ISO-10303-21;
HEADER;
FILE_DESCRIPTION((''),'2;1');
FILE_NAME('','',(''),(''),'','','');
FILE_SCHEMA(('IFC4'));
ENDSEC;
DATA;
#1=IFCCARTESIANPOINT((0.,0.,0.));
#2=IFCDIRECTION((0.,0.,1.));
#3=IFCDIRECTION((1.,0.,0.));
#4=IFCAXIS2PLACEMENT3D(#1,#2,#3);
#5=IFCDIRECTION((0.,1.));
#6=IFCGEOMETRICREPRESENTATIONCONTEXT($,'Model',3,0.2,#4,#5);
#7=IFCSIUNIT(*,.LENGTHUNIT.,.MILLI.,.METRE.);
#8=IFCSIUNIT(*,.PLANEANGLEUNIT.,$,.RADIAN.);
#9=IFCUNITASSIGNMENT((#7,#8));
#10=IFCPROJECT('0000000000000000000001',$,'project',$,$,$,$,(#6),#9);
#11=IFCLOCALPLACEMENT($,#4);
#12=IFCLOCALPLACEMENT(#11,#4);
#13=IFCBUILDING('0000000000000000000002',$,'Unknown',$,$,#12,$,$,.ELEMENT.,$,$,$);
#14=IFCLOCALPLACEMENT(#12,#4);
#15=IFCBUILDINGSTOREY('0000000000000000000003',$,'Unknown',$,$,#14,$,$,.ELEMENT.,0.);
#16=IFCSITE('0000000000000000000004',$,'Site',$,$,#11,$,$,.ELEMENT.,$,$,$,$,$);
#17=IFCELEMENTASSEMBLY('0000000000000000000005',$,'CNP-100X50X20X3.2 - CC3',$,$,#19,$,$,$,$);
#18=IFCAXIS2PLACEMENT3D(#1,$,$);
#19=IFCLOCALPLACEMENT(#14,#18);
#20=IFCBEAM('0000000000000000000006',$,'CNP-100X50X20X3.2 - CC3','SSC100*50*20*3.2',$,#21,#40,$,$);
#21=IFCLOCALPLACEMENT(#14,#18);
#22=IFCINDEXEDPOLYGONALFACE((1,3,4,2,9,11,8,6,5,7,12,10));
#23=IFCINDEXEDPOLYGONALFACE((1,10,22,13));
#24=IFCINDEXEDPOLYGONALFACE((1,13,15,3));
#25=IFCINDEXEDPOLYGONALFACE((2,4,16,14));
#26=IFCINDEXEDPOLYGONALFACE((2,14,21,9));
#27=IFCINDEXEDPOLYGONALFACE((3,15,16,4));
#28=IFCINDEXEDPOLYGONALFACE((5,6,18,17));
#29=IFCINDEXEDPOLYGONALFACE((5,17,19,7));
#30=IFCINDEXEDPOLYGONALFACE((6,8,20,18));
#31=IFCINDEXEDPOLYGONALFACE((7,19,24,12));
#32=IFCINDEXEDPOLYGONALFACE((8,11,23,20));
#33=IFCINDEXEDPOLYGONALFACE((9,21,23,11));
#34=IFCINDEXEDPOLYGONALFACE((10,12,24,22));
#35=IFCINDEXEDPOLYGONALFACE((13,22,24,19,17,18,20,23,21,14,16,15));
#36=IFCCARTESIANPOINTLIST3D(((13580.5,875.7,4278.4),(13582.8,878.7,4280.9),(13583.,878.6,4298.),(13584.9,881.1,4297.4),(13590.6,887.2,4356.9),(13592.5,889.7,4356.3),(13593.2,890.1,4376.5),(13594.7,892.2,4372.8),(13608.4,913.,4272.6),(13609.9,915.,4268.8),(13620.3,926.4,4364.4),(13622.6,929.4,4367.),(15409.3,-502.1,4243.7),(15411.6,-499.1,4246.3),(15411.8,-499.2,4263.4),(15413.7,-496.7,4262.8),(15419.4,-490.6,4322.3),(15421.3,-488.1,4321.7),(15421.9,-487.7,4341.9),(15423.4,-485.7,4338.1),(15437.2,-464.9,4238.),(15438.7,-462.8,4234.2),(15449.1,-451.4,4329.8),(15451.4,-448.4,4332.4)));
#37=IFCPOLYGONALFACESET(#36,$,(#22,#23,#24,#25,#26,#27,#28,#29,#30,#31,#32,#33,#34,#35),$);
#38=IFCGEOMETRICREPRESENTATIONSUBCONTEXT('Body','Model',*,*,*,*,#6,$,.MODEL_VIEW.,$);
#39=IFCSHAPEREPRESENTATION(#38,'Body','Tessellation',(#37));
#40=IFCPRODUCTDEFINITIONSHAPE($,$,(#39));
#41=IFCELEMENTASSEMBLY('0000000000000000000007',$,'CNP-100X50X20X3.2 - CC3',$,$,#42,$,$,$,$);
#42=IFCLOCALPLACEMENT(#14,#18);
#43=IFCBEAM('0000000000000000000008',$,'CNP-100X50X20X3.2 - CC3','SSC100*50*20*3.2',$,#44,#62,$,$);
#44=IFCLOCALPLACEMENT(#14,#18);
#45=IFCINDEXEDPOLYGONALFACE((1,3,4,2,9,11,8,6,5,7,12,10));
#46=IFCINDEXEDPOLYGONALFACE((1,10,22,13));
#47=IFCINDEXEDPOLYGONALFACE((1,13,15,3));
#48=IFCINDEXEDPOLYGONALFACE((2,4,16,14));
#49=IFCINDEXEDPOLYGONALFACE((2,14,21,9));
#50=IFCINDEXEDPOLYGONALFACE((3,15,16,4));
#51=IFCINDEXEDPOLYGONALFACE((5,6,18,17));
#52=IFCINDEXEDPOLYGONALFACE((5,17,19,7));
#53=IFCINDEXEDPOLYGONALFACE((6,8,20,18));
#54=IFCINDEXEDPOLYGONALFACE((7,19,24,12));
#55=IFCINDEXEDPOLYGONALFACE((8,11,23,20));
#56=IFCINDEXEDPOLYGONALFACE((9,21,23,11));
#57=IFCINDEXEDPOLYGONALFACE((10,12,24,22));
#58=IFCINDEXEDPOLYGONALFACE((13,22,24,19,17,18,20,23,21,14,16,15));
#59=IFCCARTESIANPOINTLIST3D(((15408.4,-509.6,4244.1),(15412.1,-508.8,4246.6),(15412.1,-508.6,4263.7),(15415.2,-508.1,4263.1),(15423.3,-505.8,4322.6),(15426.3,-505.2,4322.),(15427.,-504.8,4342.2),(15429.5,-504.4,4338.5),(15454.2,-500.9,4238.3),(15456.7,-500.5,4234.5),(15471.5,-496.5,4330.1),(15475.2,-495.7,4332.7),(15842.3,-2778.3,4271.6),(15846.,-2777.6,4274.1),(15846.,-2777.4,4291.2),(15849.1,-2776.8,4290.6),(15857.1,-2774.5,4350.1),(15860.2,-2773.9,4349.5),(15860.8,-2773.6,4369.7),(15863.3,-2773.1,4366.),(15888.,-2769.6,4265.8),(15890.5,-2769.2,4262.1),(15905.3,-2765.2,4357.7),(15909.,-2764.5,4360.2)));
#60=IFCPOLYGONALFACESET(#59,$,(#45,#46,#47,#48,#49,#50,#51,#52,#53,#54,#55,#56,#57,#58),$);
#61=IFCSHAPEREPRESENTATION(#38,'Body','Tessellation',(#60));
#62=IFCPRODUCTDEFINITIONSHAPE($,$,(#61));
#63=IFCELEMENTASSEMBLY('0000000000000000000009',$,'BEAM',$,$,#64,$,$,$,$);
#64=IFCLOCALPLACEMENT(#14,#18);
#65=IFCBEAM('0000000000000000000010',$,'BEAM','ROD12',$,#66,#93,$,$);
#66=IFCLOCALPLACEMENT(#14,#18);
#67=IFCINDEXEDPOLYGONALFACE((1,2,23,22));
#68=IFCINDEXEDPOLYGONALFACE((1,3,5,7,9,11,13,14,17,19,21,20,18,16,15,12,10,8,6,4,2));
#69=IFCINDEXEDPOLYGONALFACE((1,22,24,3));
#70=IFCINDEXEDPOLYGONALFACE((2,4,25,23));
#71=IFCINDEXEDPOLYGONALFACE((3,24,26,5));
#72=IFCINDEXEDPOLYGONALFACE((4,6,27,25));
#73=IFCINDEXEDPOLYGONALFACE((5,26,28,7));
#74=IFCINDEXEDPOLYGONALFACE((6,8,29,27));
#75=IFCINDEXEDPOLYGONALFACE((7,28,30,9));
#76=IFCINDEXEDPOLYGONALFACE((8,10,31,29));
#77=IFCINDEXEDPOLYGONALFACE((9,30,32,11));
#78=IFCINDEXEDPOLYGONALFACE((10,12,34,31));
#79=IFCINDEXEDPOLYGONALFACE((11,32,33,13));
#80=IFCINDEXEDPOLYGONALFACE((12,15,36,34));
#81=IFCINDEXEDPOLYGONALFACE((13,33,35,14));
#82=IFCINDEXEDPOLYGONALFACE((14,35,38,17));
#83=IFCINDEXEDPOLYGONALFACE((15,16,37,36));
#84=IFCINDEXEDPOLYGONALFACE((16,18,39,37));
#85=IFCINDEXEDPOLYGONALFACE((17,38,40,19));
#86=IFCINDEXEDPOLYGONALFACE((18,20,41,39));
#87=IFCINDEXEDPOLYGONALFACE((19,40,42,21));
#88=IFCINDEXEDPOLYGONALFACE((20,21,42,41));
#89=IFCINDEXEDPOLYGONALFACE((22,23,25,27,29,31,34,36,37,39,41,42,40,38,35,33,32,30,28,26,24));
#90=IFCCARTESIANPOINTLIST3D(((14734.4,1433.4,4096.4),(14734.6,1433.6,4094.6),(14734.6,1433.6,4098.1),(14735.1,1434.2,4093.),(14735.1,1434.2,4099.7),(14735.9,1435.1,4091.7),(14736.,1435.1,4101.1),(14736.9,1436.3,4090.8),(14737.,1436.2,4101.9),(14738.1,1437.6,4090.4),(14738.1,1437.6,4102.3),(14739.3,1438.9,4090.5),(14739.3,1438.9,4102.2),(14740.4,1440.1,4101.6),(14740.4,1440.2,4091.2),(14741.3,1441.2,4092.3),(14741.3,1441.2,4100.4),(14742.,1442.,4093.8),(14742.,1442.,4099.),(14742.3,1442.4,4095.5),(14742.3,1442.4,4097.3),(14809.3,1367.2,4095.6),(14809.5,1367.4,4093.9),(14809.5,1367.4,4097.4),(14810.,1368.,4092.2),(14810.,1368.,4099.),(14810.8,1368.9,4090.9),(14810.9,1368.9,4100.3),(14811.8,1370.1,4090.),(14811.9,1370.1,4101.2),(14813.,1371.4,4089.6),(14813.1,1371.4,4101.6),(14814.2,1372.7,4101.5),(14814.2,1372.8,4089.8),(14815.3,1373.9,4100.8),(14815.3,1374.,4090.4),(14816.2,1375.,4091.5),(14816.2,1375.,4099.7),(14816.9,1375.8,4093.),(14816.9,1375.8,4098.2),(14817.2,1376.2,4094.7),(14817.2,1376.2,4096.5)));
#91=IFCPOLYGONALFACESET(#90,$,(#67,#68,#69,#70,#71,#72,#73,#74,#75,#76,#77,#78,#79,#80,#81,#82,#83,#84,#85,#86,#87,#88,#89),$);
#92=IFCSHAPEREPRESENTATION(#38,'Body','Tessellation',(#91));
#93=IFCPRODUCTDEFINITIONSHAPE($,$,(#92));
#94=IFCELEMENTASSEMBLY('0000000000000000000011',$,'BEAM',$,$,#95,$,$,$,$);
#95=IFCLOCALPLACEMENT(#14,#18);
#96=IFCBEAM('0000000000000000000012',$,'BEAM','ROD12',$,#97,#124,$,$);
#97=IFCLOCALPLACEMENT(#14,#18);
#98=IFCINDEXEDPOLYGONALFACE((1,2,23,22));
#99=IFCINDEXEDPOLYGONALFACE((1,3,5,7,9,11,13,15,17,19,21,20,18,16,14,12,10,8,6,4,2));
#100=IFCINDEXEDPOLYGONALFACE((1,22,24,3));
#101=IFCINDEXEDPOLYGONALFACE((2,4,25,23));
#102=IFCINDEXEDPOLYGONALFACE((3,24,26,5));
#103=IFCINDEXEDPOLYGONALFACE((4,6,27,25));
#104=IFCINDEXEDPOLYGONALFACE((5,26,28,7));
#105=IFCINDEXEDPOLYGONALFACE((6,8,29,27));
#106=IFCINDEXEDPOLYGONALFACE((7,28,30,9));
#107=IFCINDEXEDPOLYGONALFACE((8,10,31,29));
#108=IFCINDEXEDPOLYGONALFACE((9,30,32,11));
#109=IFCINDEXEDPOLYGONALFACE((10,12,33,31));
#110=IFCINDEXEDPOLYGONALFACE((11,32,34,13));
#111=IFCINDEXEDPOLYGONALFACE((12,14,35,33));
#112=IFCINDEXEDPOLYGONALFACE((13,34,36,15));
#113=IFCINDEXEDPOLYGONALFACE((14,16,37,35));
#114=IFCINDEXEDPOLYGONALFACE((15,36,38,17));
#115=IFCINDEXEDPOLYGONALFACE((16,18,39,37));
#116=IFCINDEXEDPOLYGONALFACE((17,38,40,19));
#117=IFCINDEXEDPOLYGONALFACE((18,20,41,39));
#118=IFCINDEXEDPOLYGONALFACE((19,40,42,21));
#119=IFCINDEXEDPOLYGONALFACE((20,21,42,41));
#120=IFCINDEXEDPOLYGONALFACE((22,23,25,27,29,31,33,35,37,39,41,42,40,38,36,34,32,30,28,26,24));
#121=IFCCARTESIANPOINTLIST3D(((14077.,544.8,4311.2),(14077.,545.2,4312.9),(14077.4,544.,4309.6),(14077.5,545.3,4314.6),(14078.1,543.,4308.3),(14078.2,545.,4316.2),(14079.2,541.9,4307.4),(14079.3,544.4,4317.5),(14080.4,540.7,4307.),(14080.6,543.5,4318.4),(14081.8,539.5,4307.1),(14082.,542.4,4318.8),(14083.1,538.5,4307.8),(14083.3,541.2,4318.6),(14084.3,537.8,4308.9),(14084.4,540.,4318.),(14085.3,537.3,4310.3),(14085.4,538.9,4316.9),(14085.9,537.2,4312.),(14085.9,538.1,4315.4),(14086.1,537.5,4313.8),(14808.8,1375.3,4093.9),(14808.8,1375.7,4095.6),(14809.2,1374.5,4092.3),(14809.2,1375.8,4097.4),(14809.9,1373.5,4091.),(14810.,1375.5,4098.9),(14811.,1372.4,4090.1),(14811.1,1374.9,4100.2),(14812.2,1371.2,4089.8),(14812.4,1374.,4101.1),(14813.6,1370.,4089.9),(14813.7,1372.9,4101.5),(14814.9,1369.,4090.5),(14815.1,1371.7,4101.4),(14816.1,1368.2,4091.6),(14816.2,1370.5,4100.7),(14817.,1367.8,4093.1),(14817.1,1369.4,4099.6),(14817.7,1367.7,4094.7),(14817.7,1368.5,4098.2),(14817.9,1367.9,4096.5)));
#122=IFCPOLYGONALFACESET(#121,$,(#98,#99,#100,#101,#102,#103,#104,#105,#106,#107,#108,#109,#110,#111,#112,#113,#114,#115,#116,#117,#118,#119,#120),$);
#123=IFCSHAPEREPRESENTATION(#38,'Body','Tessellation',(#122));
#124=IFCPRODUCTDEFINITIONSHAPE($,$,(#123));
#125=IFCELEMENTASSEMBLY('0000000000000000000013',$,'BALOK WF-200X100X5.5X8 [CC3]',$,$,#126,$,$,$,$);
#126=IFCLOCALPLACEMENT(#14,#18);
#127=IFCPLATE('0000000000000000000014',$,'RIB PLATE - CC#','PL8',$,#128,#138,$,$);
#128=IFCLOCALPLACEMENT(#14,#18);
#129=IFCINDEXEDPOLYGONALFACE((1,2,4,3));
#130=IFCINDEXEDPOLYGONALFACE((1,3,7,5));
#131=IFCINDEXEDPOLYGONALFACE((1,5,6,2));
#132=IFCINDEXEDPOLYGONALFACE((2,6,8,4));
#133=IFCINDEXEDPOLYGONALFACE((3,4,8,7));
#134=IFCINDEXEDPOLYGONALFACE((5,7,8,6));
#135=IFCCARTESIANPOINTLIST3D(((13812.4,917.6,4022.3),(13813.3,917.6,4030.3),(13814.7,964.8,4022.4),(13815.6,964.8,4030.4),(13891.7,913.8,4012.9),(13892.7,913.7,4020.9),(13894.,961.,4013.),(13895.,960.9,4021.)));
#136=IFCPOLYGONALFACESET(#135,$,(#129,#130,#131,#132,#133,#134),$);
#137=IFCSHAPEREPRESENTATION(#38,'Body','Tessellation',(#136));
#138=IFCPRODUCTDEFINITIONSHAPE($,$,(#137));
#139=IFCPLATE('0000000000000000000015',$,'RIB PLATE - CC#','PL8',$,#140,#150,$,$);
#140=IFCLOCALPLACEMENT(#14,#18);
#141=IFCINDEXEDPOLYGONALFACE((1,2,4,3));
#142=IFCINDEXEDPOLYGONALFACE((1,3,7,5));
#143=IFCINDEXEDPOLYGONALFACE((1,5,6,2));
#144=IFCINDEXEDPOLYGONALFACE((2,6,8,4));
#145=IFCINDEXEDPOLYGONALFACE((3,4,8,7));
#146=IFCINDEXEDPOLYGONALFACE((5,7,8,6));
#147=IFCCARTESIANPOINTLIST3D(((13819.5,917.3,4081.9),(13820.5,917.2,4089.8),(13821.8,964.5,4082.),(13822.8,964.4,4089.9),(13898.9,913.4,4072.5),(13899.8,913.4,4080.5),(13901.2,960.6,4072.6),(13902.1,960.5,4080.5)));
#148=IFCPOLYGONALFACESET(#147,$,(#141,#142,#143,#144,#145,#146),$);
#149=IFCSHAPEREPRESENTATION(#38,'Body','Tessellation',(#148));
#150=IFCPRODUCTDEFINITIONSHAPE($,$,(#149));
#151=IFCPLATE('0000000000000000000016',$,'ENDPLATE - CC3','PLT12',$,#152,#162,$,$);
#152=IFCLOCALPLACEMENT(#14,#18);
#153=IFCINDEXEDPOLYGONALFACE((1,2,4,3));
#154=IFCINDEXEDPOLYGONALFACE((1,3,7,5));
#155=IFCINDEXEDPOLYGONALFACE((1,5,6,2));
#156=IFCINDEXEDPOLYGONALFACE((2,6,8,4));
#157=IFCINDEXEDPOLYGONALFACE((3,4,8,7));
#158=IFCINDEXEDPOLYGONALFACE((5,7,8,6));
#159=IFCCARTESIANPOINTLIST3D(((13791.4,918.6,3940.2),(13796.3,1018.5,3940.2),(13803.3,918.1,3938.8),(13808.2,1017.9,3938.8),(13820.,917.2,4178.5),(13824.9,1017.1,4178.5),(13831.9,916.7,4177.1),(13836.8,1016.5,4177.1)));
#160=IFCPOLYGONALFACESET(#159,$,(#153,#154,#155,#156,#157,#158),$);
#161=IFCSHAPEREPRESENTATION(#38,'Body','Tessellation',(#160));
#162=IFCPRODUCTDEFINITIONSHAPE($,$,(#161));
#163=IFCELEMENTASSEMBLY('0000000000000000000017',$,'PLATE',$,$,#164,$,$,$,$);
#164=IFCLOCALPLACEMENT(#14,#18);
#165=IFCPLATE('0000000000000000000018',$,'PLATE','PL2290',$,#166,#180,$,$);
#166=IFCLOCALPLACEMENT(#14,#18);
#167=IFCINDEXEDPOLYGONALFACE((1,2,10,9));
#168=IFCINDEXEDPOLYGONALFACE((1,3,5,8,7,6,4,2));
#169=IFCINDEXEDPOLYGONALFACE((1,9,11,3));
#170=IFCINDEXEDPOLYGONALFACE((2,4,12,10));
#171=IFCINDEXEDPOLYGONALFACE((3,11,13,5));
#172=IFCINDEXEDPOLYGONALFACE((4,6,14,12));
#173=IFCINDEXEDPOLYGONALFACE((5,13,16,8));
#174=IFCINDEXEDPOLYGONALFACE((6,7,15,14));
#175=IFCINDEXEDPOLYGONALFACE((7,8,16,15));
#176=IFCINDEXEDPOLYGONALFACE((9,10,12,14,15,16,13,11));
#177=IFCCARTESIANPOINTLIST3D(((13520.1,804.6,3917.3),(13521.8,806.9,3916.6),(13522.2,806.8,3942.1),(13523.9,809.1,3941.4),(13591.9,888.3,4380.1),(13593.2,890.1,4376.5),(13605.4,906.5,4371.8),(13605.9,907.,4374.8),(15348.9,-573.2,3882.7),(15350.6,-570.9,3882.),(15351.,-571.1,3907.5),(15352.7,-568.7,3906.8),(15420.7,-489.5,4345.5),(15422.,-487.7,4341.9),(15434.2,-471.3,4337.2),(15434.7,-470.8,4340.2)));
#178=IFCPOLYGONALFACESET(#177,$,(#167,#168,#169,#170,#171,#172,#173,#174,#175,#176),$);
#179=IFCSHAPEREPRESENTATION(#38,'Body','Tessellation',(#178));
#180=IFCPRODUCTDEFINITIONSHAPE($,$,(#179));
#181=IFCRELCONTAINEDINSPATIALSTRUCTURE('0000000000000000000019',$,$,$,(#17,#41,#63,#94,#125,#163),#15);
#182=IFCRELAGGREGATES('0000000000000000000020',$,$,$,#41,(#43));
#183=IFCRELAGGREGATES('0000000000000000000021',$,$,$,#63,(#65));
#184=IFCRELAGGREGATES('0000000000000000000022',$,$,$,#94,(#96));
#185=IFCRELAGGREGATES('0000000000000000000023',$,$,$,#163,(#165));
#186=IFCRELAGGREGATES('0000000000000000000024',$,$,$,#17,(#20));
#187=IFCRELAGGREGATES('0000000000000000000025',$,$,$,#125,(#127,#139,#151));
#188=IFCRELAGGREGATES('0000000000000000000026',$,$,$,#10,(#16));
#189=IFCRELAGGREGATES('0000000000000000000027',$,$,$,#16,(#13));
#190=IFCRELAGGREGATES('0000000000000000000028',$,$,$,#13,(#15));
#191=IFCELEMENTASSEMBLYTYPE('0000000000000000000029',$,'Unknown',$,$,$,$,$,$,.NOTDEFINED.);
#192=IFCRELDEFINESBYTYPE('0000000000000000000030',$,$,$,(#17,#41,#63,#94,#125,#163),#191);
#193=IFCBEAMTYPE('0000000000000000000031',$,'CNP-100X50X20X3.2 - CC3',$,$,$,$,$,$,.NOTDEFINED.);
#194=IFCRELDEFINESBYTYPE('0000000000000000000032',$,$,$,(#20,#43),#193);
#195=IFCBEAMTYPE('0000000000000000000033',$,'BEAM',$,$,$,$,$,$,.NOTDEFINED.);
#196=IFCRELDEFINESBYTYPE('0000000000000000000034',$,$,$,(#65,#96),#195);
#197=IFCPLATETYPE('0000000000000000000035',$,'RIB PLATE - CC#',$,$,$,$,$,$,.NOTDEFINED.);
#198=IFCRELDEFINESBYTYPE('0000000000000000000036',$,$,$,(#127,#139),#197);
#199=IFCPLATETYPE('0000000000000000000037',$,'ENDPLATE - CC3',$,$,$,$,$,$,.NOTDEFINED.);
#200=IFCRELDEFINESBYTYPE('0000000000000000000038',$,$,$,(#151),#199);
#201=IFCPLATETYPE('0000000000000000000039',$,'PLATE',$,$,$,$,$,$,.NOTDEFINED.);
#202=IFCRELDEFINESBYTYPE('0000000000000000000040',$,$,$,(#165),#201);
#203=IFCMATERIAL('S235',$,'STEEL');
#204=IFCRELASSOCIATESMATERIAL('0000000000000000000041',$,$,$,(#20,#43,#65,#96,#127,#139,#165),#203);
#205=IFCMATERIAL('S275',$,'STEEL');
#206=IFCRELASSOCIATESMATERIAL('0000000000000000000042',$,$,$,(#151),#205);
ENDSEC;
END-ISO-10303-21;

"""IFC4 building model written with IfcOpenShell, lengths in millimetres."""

from ifc_helpers import new_model, si_unit, direction, frame, origin_with_axes, origin_2d_with_axis, place, context, subcontext, project, spatial, line, indexed_curve, circle, c_section, outline, extrude, material, material_profile, profile_set, profile_usage, type_object, element, aggregate, save


model = new_model("IFC4")

# Units and contexts
model_context = context("Model", 3, precision=0.2, world=origin_with_axes(), true_north=direction((0.0, 1.0)))
body_context = subcontext(model_context, "Body", "Model", "MODEL_VIEW")
ifc_project = project(units=[si_unit("LENGTHUNIT", "METRE", prefix="MILLI"), si_unit("PLANEANGLEUNIT", "RADIAN")], contexts=[model_context])

# Site, building, storey
site_placement = place(None, origin_with_axes())
site = spatial("IfcSite", under=ifc_project, at=site_placement, Name="Site", CompositionType="ELEMENT")
building_placement = place(site_placement, origin_with_axes())
building = spatial("IfcBuilding", under=site, at=building_placement, Name="Unknown", CompositionType="ELEMENT")
storey_placement = place(building_placement, origin_with_axes())
storey = spatial("IfcBuildingStorey", under=building, at=storey_placement, Name="Unknown", CompositionType="ELEMENT", Elevation=0.0)

# Shared definitions
element_assembly_type = type_object("IfcElementAssemblyType", Name="Unknown", PredefinedType="NOTDEFINED")

# Element assemblies, beams
assembly_1_placement = place(storey_placement, frame((13601.5, 902.6, 4322.7), z_axis=(-0.588388, -0.785748, 0.190787), x_axis=(0.798594, -0.60168, -0.015122)))
assembly_1 = element("IfcElementAssembly", 1, at=assembly_1_placement, inside=storey, type_object=element_assembly_type, Name="CNP-100X50X20X3.2 - CC3")
ifc_material_1 = material(Name="S235", Category="STEEL")
ifc_material_profile_1 = material_profile(ifc_material_1, c_section(Depth=100.0, Width=50.0, WallThickness=3.2, Girth=20.0, at=origin_2d_with_axis()), Name="SSC100*50*20*3.2")
ifc_profile_set_1 = profile_set([ifc_material_profile_1])
ifc_profile_usage_1 = profile_usage(ifc_profile_set_1, cardinal=4)
beam_type_1 = type_object("IfcBeamType", Name="CNP-100X50X20X3.2 - CC3", PredefinedType="NOTDEFINED")
beam_1_placement = place(assembly_1_placement, origin_with_axes())
beam_1 = element("IfcBeam", 2, at=beam_1_placement, type_object=beam_type_1, material=ifc_profile_usage_1, Name="CNP-100X50X20X3.2 - CC3", Description="SSC100*50*20*3.2", context=body_context, shape_type="SolidModel", body=[
    extrude(c_section(Depth=100.0, Width=50.0, WallThickness=3.2, Girth=20.0, at=origin_2d_with_axis()), frame((0.0, 0.0, 0.0), z_axis=(-1.0, 0.0, 0.0), x_axis=(0.0, 0.0, 1.0)), (0.0, 0.0, -1.0), 2290.0),
])
assembly_2_placement = place(storey_placement, frame((15441.8, -502.7, 4288.4), z_axis=(-0.964585, -0.182136, 0.190795), x_axis=(0.187807, -0.982134, 0.011917)))
assembly_2 = element("IfcElementAssembly", 3, at=assembly_2_placement, inside=storey, type_object=element_assembly_type, Name="CNP-100X50X20X3.2 - CC3")
beam_2_placement = place(assembly_2_placement, origin_with_axes())
beam_2 = element("IfcBeam", 4, at=beam_2_placement, type_object=beam_type_1, material=ifc_profile_usage_1, Name="CNP-100X50X20X3.2 - CC3", Description="SSC100*50*20*3.2", context=body_context, shape_type="SolidModel", body=[
    extrude(c_section(Depth=100.0, Width=50.0, WallThickness=3.2, Girth=20.0, at=origin_2d_with_axis()), frame((0.0, 0.0, 0.0), z_axis=(-1.0, 0.0, 0.0), x_axis=(0.0, 0.0, 1.0)), (0.0, 0.0, -1.0), 2310.0),
])
aggregate(assembly_2, [beam_2])
assembly_3_placement = place(storey_placement, frame((14738.4, 1437.9, 4096.4), z_axis=(-0.662208, -0.74932, 0.0), x_axis=(0.7493, -0.66219, -0.007395)))
assembly_3 = element("IfcElementAssembly", 5, at=assembly_3_placement, inside=storey, type_object=element_assembly_type, Name="BEAM")
ifc_material_profile_2 = material_profile(ifc_material_1, circle(Radius=6.0, at=origin_2d_with_axis()), Name="ROD12")
ifc_profile_set_2 = profile_set([ifc_material_profile_2])
ifc_profile_usage_2 = profile_usage(ifc_profile_set_2, cardinal=5)
beam_type_2 = type_object("IfcBeamType", Name="BEAM", PredefinedType="NOTDEFINED")
beam_3_placement = place(assembly_3_placement, origin_with_axes())
beam_3 = element("IfcBeam", 6, at=beam_3_placement, type_object=beam_type_2, material=ifc_profile_usage_2, Name="BEAM", Description="ROD12", context=body_context, shape_type="SolidModel", body=[
    extrude(circle(Radius=6.0, at=origin_2d_with_axis()), frame((0.0, 0.0, 0.0), z_axis=(-1.0, 0.0, 0.0), x_axis=(0.0, 0.0, 1.0)), (0.0, 0.0, -1.0), 100.0),
])
aggregate(assembly_3, [beam_3])
assembly_4_placement = place(storey_placement, frame((14813.3, 1371.7, 4095.6), z_axis=(-0.750281, 0.661119, 0.0), x_axis=(-0.64874, -0.736232, 0.192612)))
assembly_4 = element("IfcElementAssembly", 7, at=assembly_4_placement, inside=storey, type_object=element_assembly_type, Name="BEAM")
beam_4_placement = place(assembly_4_placement, origin_with_axes())
beam_4 = element("IfcBeam", 8, at=beam_4_placement, type_object=beam_type_2, material=ifc_profile_usage_2, Name="BEAM", Description="ROD12", context=body_context, shape_type="SolidModel", body=[
    extrude(circle(Radius=6.0, at=origin_2d_with_axis()), frame((0.0, 0.0, 0.0), z_axis=(-1.0, 0.0, 0.0), x_axis=(0.0, 0.0, 1.0)), (0.0, 0.0, -1.0), 1128.0),
])
aggregate(assembly_4, [beam_4])

# Shared definitions
ifc_material_2 = material(Name="S275", Category="STEEL")

# Element assembly, plates
ifc_material_profile_3 = material_profile(ifc_material_1, outline(indexed_curve([(0.0, 0.0), (80.0, 0.0), (80.0, 47.2), (0.0, 47.2)], segments=[line(1, 2, 3, 4, 1)])), Name="PL8")
ifc_profile_set_3 = profile_set([ifc_material_profile_3])
ifc_profile_usage_3 = profile_usage(ifc_profile_set_3, cardinal=5)
plate_type_1 = type_object("IfcPlateType", Name="RIB PLATE - CC#", PredefinedType="NOTDEFINED")
assembly_5_placement = place(storey_placement, frame((17280.0, 797.8, 3641.8), z_axis=(0.048943, 0.998802, 0.0), x_axis=(-0.991673, 0.048594, 0.119261)))
assembly_5 = element("IfcElementAssembly", 9, at=assembly_5_placement, inside=storey, type_object=element_assembly_type, Name="BALOK WF-200X100X5.5X8 [CC3]")
plate_1_placement = place(assembly_5_placement, frame((3490.0, -32.0, -50.0), z_axis=(0.002003, 0.999996, -0.001788), x_axis=(-0.999998, 0.002003, 0.000054)))
plate_1 = element("IfcPlate", 10, at=plate_1_placement, type_object=plate_type_1, material=ifc_profile_usage_3, Name="RIB PLATE - CC#", Description="PL8", context=body_context, shape_type="SolidModel", body=[
    extrude(outline(indexed_curve([(0.0, 0.0), (80.0, 0.0), (80.0, 47.2), (0.0, 47.2)], segments=[line(1, 2, 3, 4, 1)])), frame((0.0, 0.0, 4.0), z_axis=(0.0, 0.0, 1.0), x_axis=(1.0, 0.0, 0.0)), (0.0, 0.0, -1.0), 8.0),
])
plate_2_placement = place(assembly_5_placement, frame((3490.0, 28.0, -50.0), z_axis=(0.002003, 0.999996, -0.001788), x_axis=(-0.999998, 0.002003, 0.000054)))
plate_2 = element("IfcPlate", 11, at=plate_2_placement, type_object=plate_type_1, material=ifc_profile_usage_3, Name="RIB PLATE - CC#", Description="PL8", context=body_context, shape_type="SolidModel", body=[
    extrude(outline(indexed_curve([(0.0, 0.0), (80.0, 0.0), (80.0, 47.2), (0.0, 47.2)], segments=[line(1, 2, 3, 4, 1)])), frame((0.0, 0.0, 4.0), z_axis=(0.0, 0.0, 1.0), x_axis=(1.0, 0.0, 0.0)), (0.0, 0.0, -1.0), 8.0),
])
ifc_material_profile_4 = material_profile(ifc_material_2, outline(indexed_curve([(0.0, 0.0), (240.0, 0.0), (240.0, 100.0), (0.0, 100.0)], segments=[line(1, 2, 3, 4, 1)])), Name="PLT12")
ifc_profile_set_4 = profile_set([ifc_material_profile_4])
ifc_profile_usage_4 = profile_usage(ifc_profile_set_4, cardinal=5)
plate_type_2 = type_object("IfcPlateType", Name="ENDPLATE - CC3", PredefinedType="NOTDEFINED")
plate_3_placement = place(assembly_5_placement, frame((3495.0, -120.0, 50.0), z_axis=(-1.0, 0.0, 0.0), x_axis=(0.0, 1.0, 0.0)))
plate_3 = element("IfcPlate", 12, at=plate_3_placement, type_object=plate_type_2, material=ifc_profile_usage_4, Name="ENDPLATE - CC3", Description="PLT12", context=body_context, shape_type="SolidModel", body=[
    extrude(outline(indexed_curve([(0.0, 0.0), (240.0, 0.0), (240.0, 100.0), (0.0, 100.0)], segments=[line(1, 2, 3, 4, 1)])), frame((0.0, 0.0, 6.0), z_axis=(0.0, 0.0, 1.0), x_axis=(1.0, 0.0, 0.0)), (0.0, 0.0, -1.0), 12.0),
])

# Element assembly, plate
assembly_6_placement = place(storey_placement, frame((14520.3, 218.1, 4357.5), z_axis=(0.7986, -0.601672, -0.015111), x_axis=(-0.584444, -0.781241, 0.219289)))
assembly_6 = element("IfcElementAssembly", 13, at=assembly_6_placement, inside=storey, type_object=element_assembly_type, Name="PLATE")
ifc_material_profile_5 = material_profile(ifc_material_1, outline(indexed_curve([(0.0, 0.0), (24.0, 0.0), (32.4, 450.9), (29.8, 475.8), (26.9, 475.8), (29.4, 450.9), (21.0, 3.0), (0.0, 3.1)], segments=[line(1, 2, 3, 4, 5, 6, 7, 8, 1)])), Name="PL2290")
ifc_profile_set_5 = profile_set([ifc_material_profile_5])
ifc_profile_usage_5 = profile_usage(ifc_profile_set_5, cardinal=5)
plate_type_3 = type_object("IfcPlateType", Name="PLATE", PredefinedType="NOTDEFINED")
plate_4_placement = place(assembly_6_placement, origin_with_axes())
plate_4 = element("IfcPlate", 14, at=plate_4_placement, type_object=plate_type_3, material=ifc_profile_usage_5, Name="PLATE", Description="PL2290", context=body_context, shape_type="SolidModel", body=[
    extrude(outline(indexed_curve([(0.0, 0.0), (24.0, 0.0), (32.4, 450.9), (29.8, 475.8), (26.9, 475.8), (29.4, 450.9), (21.0, 3.0), (0.0, 3.1)], segments=[line(1, 2, 3, 4, 5, 6, 7, 8, 1)])), frame((0.0, 0.0, 1145.0), z_axis=(0.0, 0.0, 1.0), x_axis=(1.0, 0.0, 0.0)), (0.0, 0.0, -1.0), 2290.0),
])
aggregate(assembly_6, [plate_4])

aggregate(assembly_1, [beam_1])
aggregate(assembly_5, [plate_1, plate_2, plate_3])

save(model, "model.ifc")
